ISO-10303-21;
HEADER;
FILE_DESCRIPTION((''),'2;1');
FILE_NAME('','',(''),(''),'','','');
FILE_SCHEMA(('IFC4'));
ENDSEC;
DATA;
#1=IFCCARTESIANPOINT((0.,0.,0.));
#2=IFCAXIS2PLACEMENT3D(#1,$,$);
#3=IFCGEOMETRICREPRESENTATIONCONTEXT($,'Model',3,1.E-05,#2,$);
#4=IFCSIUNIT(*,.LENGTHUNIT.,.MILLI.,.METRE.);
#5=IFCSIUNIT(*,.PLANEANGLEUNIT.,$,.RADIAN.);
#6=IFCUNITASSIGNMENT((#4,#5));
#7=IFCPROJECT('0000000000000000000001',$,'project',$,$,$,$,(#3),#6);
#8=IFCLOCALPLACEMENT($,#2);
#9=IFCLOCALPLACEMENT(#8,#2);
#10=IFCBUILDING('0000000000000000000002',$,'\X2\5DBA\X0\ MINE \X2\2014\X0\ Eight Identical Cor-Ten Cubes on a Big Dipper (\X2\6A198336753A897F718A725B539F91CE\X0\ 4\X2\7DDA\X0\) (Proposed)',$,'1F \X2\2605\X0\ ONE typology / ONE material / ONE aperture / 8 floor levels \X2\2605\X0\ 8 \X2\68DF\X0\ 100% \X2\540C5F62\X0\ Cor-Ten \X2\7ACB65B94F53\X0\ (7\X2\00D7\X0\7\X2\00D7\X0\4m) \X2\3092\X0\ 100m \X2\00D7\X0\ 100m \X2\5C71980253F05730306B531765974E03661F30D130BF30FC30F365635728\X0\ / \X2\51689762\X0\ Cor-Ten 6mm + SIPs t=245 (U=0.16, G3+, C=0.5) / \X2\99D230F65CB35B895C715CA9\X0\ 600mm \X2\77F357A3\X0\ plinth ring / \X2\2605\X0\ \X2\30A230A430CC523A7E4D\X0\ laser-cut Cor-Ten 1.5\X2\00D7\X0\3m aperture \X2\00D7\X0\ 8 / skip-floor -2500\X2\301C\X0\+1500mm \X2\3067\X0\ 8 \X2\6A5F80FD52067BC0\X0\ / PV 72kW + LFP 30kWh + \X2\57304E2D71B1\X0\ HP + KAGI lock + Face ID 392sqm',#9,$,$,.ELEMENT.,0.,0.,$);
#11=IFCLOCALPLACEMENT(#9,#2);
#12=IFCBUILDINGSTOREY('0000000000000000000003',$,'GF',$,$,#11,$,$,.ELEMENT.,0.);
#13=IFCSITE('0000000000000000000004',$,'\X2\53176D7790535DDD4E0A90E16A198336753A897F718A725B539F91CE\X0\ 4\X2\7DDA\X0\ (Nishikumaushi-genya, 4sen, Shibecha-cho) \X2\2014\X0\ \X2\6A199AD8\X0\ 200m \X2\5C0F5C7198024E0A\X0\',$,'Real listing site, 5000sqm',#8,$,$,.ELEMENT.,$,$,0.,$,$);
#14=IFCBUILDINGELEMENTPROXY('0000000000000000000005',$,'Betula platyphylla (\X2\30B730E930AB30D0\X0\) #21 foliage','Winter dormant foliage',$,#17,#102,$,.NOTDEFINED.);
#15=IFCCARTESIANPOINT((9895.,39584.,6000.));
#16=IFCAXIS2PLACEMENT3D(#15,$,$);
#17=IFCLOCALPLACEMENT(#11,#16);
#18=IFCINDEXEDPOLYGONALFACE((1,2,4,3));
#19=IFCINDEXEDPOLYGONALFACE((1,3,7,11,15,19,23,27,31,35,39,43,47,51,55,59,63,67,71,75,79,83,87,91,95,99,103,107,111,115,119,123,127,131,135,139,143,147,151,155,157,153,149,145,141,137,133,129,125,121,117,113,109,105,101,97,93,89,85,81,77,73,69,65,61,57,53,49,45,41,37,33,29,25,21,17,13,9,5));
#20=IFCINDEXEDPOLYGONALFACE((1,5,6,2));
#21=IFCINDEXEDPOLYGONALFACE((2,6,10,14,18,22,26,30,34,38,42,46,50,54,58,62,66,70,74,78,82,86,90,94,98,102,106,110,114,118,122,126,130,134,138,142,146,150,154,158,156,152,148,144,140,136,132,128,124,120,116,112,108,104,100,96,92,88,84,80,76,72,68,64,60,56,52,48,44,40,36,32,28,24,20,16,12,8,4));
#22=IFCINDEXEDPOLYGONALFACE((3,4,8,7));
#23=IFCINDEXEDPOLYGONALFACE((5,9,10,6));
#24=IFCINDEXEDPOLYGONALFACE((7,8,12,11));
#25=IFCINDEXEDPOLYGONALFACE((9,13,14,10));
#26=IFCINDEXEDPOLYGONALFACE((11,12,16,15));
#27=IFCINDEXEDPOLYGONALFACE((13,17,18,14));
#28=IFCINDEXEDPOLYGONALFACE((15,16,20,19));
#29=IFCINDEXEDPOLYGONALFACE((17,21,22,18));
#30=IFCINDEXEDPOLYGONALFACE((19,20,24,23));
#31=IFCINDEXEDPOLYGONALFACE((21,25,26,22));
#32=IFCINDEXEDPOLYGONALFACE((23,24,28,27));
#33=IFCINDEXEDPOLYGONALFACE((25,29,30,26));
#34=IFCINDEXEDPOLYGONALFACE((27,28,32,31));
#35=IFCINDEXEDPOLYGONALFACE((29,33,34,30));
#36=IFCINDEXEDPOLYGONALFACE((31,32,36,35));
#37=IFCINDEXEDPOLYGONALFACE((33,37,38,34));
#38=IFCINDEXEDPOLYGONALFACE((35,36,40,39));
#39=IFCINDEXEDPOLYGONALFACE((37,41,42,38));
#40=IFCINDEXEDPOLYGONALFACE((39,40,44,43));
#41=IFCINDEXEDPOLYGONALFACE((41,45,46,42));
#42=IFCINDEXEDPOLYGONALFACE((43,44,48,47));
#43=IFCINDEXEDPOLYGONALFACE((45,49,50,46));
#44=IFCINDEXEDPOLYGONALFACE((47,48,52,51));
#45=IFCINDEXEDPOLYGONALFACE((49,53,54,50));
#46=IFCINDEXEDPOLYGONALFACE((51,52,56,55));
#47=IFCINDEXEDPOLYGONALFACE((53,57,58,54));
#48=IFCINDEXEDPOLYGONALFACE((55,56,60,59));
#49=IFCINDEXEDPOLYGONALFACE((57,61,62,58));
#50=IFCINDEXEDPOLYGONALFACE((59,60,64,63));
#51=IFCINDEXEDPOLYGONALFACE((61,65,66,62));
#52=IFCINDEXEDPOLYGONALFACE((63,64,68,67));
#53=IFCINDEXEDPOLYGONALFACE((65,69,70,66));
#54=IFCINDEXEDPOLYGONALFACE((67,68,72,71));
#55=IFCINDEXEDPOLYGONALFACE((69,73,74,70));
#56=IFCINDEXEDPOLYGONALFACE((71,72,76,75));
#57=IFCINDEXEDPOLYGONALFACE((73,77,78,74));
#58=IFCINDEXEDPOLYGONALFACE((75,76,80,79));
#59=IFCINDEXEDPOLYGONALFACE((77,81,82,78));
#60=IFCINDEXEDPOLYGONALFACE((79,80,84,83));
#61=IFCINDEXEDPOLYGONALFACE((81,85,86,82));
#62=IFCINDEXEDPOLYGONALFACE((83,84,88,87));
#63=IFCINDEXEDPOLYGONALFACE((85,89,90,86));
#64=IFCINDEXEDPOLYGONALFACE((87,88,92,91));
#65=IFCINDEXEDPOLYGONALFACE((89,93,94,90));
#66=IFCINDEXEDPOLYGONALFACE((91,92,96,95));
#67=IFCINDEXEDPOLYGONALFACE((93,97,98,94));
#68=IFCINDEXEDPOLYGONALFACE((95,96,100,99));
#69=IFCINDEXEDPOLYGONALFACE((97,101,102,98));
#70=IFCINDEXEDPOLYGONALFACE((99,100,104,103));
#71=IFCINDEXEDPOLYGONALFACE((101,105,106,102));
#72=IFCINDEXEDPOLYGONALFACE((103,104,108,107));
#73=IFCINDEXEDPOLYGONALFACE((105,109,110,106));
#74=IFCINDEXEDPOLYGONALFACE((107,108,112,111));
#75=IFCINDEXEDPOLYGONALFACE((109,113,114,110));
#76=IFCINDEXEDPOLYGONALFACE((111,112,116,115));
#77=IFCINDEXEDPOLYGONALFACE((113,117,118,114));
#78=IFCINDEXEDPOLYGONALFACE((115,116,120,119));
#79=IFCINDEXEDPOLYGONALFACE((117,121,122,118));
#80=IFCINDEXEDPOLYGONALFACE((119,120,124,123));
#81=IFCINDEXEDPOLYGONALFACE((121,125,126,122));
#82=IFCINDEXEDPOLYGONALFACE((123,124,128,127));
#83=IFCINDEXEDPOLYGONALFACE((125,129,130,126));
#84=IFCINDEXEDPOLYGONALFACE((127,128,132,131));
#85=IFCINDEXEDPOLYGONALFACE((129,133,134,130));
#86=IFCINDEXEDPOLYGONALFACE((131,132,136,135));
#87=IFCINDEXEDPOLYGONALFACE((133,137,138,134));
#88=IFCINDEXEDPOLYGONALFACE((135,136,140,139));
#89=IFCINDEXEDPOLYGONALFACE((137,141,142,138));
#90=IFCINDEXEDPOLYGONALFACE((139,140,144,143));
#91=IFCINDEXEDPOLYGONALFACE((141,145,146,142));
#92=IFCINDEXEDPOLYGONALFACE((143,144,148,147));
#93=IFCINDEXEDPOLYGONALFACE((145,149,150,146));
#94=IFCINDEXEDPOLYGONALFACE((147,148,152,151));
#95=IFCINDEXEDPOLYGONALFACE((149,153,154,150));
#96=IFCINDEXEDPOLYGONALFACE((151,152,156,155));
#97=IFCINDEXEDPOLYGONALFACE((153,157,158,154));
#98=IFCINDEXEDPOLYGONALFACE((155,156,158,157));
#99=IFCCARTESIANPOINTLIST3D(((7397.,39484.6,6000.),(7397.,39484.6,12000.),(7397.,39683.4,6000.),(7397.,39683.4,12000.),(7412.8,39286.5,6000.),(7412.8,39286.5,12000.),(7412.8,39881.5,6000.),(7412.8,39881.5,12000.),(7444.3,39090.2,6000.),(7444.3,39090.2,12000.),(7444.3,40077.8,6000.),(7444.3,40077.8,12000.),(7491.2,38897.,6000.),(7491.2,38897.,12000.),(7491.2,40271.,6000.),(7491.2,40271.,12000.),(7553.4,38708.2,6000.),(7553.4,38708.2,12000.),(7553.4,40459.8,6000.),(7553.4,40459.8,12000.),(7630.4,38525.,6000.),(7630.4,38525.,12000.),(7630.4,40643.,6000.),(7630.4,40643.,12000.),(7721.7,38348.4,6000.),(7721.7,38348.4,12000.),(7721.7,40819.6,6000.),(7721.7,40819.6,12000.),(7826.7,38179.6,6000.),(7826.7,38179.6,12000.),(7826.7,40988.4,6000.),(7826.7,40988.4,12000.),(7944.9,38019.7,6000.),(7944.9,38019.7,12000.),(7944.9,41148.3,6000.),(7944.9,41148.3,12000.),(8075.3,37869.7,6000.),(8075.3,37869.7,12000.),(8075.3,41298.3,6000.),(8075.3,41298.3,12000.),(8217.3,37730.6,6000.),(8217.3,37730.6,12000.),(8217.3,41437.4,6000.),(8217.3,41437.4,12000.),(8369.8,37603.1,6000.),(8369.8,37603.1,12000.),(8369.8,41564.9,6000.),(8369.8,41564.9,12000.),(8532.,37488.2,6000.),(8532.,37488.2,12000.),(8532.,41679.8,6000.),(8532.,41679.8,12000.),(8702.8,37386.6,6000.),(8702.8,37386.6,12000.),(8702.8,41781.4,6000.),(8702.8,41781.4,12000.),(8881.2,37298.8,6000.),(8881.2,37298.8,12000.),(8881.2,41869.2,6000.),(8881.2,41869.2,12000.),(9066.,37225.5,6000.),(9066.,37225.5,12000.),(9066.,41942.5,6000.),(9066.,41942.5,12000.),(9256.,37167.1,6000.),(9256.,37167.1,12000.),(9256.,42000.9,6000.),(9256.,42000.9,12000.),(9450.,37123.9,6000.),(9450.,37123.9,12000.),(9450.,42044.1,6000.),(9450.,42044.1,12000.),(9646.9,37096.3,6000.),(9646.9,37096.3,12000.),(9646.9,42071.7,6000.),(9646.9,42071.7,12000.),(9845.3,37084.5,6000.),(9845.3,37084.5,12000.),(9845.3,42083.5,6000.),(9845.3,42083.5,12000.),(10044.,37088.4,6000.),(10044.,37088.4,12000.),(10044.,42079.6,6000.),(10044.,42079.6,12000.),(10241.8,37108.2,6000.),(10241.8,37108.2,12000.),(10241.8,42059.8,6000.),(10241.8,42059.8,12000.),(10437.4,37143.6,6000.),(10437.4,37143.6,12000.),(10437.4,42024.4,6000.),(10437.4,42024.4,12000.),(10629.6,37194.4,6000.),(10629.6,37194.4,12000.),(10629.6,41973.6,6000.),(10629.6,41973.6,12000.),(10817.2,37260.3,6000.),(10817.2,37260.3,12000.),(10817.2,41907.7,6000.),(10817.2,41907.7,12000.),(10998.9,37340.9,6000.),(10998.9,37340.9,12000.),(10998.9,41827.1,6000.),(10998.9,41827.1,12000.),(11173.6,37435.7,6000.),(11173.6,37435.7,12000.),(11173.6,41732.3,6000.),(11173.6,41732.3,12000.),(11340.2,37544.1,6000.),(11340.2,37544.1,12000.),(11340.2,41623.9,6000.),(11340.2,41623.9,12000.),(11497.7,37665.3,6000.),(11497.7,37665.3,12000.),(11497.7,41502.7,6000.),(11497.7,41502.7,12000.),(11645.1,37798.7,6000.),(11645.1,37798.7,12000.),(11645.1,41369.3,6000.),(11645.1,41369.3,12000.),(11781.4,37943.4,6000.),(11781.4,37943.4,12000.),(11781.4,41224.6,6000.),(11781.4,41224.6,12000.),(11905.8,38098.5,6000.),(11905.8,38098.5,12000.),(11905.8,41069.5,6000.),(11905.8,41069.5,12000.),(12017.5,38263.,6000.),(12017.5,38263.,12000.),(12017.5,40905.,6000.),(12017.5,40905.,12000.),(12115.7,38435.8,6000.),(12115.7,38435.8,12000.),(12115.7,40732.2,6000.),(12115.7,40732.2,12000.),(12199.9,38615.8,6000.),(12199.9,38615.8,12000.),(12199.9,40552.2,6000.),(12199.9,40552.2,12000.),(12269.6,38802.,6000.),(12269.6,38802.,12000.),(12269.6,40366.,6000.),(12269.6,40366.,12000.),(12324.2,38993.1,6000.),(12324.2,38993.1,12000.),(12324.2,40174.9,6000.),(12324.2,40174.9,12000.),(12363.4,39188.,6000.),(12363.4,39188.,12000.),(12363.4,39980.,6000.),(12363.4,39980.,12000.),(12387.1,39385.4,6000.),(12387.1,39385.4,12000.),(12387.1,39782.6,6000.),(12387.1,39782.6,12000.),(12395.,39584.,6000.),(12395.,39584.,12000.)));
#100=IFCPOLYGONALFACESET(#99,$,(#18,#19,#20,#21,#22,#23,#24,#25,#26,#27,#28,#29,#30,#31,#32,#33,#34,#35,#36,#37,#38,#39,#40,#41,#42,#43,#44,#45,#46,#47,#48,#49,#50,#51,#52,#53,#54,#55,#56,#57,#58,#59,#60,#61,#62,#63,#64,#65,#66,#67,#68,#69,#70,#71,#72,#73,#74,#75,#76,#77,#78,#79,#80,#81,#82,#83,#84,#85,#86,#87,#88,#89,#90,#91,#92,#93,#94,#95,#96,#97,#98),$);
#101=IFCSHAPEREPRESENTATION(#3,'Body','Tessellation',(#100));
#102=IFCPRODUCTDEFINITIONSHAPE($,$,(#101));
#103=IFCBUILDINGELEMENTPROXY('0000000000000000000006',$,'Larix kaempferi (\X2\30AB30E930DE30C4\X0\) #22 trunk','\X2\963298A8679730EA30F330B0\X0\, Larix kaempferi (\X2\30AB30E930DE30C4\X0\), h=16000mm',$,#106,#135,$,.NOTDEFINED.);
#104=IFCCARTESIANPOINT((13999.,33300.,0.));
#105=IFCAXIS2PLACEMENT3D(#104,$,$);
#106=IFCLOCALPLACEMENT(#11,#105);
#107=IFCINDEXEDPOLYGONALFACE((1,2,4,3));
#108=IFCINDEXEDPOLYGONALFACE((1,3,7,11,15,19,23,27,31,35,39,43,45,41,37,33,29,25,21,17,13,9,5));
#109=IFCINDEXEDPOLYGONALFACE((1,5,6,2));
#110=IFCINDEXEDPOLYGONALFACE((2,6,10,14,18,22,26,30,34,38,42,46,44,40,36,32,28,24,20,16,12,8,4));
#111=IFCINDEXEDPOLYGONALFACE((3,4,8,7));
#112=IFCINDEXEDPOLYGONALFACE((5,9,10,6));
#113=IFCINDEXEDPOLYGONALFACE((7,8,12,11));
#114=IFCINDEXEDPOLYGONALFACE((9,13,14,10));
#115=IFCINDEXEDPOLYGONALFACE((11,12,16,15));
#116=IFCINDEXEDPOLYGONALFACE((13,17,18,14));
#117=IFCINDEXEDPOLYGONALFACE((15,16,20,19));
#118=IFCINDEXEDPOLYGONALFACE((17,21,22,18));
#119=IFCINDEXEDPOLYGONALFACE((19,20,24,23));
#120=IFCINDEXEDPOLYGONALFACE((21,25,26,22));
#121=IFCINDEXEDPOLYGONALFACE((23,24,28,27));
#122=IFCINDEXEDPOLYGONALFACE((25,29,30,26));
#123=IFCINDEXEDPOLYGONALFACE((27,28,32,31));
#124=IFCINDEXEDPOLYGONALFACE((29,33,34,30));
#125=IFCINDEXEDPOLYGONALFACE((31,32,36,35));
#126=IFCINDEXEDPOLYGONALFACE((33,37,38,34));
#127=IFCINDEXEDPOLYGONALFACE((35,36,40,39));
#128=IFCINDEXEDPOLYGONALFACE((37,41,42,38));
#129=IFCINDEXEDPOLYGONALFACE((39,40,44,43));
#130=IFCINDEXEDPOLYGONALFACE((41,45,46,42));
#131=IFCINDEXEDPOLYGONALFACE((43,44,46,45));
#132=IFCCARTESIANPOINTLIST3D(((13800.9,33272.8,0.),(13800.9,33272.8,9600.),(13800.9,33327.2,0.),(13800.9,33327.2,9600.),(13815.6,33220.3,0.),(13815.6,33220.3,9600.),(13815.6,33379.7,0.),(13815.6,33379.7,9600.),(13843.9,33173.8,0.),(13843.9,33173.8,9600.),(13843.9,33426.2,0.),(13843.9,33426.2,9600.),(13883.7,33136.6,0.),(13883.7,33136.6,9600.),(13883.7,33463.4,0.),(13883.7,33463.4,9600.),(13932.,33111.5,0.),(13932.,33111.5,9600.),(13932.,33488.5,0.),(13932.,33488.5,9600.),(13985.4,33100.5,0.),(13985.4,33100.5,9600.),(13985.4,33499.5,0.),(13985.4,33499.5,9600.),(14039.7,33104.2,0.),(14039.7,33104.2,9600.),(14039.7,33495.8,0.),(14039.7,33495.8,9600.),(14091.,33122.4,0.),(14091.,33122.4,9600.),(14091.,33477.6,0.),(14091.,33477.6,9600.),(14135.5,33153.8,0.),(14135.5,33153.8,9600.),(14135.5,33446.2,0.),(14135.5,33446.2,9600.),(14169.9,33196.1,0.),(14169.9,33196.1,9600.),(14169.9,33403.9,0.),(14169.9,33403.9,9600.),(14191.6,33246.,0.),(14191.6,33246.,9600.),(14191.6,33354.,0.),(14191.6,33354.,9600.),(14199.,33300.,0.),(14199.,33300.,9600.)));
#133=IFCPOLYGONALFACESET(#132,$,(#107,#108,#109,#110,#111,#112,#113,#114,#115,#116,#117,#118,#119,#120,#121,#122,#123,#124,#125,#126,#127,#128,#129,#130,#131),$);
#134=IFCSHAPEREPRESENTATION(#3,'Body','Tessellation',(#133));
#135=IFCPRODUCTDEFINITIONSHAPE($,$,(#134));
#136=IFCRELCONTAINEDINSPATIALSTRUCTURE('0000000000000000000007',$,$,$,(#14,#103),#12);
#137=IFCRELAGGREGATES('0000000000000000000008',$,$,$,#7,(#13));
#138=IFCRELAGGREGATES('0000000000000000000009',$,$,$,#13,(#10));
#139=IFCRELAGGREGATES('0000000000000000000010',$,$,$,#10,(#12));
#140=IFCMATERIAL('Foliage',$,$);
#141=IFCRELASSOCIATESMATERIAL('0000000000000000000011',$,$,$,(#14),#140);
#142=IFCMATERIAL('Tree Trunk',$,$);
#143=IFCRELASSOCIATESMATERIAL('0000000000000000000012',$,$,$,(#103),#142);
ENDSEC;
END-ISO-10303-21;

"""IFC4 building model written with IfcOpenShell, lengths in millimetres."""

from ifc_helpers import new_model, si_unit, frame, origin, origin_2d, place, context, project, spatial, circle, extrude, material, element, save


model = new_model("IFC4")

# Units and contexts
model_context = context("Model", 3, precision=1e-05, world=origin())
ifc_project = project(units=[si_unit("LENGTHUNIT", "METRE", prefix="MILLI"), si_unit("PLANEANGLEUNIT", "RADIAN")], contexts=[model_context])

# Site, building, storey
site_placement = place(None, origin())
site = spatial("IfcSite", under=ifc_project, at=site_placement, Name="北海道川上郡標茶町西熊牛原野 4線 (Nishikumaushi-genya, 4sen, Shibecha-cho) — 標高 200m 小山頂上", ObjectType="Real listing site, 5000sqm", CompositionType="ELEMENT", RefElevation=0.0)
building_placement = place(site_placement, origin())
building = spatial("IfcBuilding", under=site, at=building_placement, Name="嶺 MINE — Eight Identical Cor-Ten Cubes on a Big Dipper (標茶町西熊牛原野 4線) (Proposed)", ObjectType="1F ★ ONE typology / ONE material / ONE aperture / 8 floor levels ★ 8 棟 100% 同形 Cor-Ten 立方体 (7×7×4m) を 100m × 100m 山頂台地に北斗七星パターン散在 / 全面 Cor-Ten 6mm + SIPs t=245 (U=0.16, G3+, C=0.5) / 駒ヶ岳安山岩 600mm 石垣 plinth ring / ★ アイヌ刺繍 laser-cut Cor-Ten 1.5×3m aperture × 8 / skip-floor -2500〜+1500mm で 8 機能分節 / PV 72kW + LFP 30kWh + 地中熱 HP + KAGI lock + Face ID 392sqm", CompositionType="ELEMENT", ElevationOfRefHeight=0.0, ElevationOfTerrain=0.0)
storey_placement = place(building_placement, origin())
storey = spatial("IfcBuildingStorey", under=building, at=storey_placement, Name="GF", CompositionType="ELEMENT", Elevation=0.0)

# Building element proxies
ifc_material_1 = material(Name="Tree Trunk")
ifc_material_2 = material(Name="Foliage")
proxy_1_placement = place(storey_placement, frame((9895.0, 39584.0, 6000.0)))
element("IfcBuildingElementProxy", 1, at=proxy_1_placement, inside=storey, material=ifc_material_2, Name="Betula platyphylla (シラカバ) #21 foliage", Description="Winter dormant foliage", PredefinedType="NOTDEFINED", context=model_context, shape_type="SweptSolid", body=[
    extrude(circle(Radius=2500.0, at=origin_2d()), frame((9895.0, 39584.0, 6000.0)), (0.0, 0.0, 1.0), 6000.0),
])
proxy_2_placement = place(storey_placement, frame((13999.0, 33300.0, 0.0)))
element("IfcBuildingElementProxy", 2, at=proxy_2_placement, inside=storey, material=ifc_material_1, Name="Larix kaempferi (カラマツ) #22 trunk", Description="防風林リング, Larix kaempferi (カラマツ), h=16000mm", PredefinedType="NOTDEFINED", context=model_context, shape_type="SweptSolid", body=[
    extrude(circle(Radius=200.0, at=origin_2d()), frame((13999.0, 33300.0, 0.0)), (0.0, 0.0, 1.0), 9600.0),
])

save(model, "model.ifc")
